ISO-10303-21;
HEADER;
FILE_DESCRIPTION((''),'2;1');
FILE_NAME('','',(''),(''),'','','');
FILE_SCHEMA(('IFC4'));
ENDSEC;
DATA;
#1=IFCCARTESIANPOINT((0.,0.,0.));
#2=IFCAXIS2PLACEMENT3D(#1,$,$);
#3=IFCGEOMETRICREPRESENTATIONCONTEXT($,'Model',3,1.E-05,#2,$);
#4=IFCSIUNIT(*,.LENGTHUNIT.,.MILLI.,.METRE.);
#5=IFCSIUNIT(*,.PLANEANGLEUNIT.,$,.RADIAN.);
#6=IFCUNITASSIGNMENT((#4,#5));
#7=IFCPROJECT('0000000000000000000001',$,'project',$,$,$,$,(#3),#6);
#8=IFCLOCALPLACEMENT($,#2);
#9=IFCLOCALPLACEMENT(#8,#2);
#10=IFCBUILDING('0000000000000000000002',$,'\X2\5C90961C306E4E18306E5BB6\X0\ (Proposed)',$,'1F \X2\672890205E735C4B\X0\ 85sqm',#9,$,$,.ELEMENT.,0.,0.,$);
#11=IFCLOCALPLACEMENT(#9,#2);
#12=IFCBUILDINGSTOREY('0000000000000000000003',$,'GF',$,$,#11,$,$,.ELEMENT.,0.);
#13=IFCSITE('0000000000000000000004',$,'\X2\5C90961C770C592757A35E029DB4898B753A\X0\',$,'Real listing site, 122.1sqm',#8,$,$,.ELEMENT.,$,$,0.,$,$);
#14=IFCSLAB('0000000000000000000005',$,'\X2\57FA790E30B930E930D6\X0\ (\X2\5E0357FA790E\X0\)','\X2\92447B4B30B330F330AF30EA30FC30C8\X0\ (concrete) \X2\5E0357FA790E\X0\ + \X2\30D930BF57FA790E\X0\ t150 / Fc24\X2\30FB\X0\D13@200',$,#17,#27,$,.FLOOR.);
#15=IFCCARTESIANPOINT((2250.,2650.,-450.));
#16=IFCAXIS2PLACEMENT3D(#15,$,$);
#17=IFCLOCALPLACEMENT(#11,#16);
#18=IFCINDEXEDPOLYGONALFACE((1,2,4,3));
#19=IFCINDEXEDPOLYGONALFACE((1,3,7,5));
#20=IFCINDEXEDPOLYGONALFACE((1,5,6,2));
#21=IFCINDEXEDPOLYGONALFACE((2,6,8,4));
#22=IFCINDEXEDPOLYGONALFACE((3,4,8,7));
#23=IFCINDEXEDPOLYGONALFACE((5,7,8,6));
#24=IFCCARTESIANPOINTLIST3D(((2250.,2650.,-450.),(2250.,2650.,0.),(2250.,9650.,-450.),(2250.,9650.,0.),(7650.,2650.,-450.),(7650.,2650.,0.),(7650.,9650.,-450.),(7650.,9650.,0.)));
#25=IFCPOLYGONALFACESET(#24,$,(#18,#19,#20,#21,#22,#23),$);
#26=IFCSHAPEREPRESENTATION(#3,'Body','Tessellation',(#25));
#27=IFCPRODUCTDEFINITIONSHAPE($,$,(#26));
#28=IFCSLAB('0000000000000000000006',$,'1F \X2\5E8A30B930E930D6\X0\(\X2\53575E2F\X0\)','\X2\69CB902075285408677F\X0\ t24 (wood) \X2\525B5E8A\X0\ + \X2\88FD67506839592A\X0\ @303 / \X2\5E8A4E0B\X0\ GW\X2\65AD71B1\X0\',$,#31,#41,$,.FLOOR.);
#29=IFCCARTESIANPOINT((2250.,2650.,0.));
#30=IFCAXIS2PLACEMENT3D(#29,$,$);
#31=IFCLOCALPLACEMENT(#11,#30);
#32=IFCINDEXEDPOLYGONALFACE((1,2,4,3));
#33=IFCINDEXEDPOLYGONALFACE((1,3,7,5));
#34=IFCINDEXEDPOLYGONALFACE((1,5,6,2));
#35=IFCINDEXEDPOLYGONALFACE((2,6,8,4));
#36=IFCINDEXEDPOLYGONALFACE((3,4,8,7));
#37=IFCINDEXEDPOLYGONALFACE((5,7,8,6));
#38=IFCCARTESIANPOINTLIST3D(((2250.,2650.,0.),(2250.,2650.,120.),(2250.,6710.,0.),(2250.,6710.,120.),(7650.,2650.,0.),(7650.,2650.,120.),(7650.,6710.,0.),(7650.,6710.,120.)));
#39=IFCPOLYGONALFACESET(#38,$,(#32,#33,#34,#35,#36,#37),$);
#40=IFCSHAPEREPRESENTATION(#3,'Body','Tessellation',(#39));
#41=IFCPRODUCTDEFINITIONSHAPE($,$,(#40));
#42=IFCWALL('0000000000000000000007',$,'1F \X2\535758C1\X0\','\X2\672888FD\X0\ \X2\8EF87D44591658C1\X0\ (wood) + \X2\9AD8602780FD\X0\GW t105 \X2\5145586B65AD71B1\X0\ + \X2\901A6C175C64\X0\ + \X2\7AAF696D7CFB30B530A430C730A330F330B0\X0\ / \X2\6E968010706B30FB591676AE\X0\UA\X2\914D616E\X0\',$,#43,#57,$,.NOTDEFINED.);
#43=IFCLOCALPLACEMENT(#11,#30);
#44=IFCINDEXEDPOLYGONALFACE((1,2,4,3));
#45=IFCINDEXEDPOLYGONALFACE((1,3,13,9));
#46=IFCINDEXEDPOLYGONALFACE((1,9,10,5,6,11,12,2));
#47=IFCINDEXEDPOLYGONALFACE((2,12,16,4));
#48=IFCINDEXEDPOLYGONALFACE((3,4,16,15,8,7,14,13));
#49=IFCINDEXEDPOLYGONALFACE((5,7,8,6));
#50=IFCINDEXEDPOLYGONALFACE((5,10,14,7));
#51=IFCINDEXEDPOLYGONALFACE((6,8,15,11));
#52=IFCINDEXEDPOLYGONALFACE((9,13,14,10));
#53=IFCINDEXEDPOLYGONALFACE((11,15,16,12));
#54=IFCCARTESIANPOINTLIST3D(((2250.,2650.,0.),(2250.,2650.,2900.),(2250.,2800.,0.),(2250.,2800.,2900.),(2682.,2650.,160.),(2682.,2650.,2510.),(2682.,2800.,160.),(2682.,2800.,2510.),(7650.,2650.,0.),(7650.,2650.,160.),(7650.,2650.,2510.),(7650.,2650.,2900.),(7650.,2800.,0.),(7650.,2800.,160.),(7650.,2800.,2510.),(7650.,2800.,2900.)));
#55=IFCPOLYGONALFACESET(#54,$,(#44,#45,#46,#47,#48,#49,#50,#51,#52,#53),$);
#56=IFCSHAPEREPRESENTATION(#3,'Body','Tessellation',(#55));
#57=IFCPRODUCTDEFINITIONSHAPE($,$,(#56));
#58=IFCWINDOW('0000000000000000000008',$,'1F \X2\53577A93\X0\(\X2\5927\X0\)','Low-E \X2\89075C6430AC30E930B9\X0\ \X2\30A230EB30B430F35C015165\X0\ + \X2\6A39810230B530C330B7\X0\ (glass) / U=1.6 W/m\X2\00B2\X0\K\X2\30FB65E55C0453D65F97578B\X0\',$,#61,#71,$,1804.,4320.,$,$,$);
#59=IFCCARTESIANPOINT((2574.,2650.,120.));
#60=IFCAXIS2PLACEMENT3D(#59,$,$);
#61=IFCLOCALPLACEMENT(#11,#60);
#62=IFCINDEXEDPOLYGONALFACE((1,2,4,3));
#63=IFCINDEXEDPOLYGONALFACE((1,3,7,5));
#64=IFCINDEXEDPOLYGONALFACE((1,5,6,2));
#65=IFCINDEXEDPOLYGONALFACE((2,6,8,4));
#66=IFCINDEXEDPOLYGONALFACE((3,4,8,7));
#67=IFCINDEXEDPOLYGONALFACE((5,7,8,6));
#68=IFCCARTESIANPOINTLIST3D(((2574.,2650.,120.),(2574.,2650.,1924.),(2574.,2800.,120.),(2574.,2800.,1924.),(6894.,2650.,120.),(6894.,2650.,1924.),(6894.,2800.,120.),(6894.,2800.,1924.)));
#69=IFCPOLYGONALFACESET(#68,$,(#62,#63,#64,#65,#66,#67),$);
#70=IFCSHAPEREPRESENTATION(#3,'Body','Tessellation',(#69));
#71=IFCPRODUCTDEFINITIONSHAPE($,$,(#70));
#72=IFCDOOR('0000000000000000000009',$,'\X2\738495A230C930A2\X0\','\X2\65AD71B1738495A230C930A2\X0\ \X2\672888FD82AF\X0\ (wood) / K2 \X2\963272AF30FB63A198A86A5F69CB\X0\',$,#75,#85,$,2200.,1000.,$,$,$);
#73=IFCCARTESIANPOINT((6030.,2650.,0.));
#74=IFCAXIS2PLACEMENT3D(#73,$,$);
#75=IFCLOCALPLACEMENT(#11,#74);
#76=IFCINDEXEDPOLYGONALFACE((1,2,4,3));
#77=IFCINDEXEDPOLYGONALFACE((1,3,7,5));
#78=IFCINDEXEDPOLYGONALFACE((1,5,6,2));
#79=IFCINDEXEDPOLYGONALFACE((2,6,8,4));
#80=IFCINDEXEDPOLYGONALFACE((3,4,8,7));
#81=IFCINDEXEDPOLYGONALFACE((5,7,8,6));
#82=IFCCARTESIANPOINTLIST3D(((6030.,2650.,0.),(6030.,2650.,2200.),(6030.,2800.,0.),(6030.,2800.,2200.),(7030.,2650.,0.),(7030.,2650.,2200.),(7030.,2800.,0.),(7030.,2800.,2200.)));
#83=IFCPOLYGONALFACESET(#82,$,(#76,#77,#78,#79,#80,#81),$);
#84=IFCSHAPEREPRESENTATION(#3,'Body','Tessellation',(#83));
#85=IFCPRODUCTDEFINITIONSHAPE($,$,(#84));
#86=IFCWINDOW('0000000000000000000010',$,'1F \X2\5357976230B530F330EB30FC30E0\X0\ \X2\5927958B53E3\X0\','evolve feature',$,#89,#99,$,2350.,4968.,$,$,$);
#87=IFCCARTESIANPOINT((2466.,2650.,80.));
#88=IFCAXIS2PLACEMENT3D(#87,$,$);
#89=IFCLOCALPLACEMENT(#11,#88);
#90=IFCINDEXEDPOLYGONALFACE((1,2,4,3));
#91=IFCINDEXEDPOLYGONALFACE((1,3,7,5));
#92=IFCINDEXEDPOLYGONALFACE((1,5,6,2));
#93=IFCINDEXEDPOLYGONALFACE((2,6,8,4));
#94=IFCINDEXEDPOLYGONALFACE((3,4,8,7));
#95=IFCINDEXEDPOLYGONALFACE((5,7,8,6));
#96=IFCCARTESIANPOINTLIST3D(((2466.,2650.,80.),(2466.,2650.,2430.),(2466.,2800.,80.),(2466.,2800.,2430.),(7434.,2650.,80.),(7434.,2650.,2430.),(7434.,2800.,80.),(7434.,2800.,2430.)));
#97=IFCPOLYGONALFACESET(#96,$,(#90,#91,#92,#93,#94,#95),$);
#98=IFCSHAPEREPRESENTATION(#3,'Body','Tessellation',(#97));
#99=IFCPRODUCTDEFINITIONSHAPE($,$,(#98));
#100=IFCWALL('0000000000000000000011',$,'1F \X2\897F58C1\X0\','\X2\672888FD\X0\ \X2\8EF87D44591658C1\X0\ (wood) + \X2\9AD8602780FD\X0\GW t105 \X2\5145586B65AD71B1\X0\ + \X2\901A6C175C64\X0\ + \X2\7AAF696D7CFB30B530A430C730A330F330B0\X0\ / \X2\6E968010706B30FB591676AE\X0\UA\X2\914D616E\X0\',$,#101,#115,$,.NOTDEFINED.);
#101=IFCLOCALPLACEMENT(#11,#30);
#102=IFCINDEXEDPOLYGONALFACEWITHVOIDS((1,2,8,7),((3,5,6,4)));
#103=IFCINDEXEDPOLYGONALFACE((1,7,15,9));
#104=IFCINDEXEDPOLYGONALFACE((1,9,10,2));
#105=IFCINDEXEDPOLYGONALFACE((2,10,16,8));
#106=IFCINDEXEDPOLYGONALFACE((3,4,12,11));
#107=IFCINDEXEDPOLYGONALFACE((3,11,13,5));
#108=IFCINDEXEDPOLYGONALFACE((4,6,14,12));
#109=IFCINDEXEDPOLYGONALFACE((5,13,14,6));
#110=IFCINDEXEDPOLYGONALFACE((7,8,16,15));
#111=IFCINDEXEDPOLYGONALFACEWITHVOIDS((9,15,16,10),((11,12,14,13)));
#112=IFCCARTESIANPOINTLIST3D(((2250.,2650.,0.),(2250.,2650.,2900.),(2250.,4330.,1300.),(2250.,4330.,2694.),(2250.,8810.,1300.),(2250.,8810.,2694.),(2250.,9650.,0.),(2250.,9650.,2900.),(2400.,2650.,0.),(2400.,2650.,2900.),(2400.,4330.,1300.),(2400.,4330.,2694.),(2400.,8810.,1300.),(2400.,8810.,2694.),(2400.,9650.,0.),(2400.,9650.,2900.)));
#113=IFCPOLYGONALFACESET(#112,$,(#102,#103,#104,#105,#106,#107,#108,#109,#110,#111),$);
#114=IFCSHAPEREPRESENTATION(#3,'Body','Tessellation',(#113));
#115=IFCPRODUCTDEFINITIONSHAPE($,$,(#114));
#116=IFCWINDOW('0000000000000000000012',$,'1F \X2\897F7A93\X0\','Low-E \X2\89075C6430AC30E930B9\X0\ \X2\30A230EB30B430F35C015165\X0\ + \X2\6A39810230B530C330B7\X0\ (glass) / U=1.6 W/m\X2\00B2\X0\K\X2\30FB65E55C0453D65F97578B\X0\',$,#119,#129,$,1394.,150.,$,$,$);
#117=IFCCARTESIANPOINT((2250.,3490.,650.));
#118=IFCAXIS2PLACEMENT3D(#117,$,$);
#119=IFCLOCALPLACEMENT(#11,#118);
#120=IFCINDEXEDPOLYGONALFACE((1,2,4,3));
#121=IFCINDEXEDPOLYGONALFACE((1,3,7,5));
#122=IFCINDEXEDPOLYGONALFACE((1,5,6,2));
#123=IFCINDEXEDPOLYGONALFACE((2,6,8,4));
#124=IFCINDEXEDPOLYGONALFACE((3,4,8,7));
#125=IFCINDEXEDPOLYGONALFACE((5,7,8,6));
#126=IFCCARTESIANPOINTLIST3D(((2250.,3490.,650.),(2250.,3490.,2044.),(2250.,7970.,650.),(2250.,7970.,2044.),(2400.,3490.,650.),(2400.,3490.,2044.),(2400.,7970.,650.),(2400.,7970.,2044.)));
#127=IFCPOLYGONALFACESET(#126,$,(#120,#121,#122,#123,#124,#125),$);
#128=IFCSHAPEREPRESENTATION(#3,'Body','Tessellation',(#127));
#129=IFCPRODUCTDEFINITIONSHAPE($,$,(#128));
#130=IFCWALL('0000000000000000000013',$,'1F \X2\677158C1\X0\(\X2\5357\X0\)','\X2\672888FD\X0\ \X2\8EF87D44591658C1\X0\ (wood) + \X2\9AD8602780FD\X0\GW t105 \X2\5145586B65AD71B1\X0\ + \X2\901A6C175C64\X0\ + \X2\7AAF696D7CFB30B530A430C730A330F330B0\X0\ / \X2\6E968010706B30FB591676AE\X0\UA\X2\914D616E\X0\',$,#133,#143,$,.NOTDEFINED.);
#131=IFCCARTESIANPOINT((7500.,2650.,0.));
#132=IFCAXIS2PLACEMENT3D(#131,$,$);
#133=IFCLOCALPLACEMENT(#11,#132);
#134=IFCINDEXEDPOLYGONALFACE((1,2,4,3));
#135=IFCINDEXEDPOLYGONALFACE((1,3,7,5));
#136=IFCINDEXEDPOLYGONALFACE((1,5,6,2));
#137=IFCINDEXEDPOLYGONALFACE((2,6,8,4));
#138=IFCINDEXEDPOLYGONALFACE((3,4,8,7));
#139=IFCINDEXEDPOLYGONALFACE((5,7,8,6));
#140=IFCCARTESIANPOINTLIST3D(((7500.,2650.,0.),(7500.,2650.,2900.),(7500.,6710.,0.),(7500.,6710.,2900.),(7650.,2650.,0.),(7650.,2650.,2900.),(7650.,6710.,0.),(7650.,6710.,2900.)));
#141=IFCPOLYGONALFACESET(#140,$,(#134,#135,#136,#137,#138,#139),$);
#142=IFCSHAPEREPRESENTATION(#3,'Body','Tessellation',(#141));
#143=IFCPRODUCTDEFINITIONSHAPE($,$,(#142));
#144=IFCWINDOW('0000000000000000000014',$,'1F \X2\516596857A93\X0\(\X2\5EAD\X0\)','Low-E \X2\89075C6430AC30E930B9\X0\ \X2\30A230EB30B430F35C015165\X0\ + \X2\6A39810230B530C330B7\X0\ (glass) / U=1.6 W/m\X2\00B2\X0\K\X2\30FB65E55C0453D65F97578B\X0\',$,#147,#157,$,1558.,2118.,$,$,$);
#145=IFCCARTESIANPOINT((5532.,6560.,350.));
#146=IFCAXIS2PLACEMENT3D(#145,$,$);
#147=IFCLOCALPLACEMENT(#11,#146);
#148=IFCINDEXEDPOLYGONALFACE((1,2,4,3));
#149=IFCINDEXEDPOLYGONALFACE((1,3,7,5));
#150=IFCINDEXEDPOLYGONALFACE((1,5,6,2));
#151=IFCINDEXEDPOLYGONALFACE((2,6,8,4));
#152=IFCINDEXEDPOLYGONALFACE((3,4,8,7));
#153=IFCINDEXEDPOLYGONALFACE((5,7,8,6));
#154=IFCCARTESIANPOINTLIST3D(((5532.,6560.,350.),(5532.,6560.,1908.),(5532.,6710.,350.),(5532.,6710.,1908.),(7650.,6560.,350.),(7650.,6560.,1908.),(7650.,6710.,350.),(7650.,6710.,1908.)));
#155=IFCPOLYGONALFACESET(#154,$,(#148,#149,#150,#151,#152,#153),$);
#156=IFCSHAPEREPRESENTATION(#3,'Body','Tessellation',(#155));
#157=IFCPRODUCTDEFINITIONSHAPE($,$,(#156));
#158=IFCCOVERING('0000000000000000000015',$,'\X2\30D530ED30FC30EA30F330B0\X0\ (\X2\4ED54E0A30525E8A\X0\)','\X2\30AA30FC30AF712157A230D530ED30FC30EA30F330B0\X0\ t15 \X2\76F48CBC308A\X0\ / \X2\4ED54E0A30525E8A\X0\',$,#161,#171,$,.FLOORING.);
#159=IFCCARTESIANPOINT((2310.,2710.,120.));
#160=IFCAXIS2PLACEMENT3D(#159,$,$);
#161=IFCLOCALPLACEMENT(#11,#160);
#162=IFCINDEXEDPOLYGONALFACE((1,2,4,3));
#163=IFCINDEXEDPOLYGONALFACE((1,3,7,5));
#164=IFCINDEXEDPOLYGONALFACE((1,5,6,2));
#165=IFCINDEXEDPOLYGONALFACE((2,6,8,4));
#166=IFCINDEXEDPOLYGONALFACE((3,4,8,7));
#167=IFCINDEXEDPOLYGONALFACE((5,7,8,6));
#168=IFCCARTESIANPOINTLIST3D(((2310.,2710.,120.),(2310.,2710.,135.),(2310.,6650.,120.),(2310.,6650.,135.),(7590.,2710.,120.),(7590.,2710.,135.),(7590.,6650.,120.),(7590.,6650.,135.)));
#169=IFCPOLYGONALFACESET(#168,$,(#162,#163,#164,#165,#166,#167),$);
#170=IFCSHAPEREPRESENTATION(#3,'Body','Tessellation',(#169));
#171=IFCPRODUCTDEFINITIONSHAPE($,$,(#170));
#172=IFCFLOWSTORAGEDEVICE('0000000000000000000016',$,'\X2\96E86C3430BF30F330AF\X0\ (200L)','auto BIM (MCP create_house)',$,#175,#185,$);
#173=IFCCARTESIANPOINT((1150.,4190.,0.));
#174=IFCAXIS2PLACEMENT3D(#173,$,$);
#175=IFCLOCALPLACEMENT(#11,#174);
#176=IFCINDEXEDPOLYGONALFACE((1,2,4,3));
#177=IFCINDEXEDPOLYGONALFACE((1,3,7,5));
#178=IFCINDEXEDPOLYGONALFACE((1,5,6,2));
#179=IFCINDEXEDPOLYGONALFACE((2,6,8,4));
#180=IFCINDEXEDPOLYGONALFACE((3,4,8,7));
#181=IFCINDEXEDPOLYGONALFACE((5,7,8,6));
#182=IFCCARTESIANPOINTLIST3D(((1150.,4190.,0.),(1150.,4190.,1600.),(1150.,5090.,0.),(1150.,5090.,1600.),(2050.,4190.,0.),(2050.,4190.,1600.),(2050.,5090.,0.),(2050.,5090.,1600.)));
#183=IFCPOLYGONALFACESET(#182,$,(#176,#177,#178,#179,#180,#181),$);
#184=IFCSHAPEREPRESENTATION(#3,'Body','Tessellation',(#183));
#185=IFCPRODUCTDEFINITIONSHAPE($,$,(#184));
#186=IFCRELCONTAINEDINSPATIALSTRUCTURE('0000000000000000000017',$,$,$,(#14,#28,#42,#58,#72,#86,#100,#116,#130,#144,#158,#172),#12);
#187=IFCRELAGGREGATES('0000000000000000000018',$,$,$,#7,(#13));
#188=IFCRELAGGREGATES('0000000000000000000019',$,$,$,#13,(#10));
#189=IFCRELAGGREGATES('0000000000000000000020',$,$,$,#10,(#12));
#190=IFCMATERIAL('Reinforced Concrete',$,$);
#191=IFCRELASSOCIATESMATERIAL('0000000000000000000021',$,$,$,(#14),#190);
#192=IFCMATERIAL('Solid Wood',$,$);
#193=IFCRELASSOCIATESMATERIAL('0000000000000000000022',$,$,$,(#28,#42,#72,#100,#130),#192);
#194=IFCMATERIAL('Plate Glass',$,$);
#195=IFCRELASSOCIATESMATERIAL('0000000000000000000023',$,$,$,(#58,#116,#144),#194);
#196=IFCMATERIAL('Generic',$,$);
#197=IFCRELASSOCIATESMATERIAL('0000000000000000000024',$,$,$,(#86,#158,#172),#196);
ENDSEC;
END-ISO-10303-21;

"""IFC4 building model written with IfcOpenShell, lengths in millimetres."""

from ifc_helpers import new_model, si_unit, frame, frame_2d, origin, place, context, project, spatial, rectangle, extrude, material, element, fill, save


model = new_model("IFC4")

# Units and contexts
model_context = context("Model", 3, precision=1e-05, world=origin())
ifc_project = project(units=[si_unit("LENGTHUNIT", "METRE", prefix="MILLI"), si_unit("PLANEANGLEUNIT", "RADIAN")], contexts=[model_context])

# Site, building, storey
site_placement = place(None, origin())
site = spatial("IfcSite", under=ifc_project, at=site_placement, Name="岐阜県大垣市鶴見町", ObjectType="Real listing site, 122.1sqm", CompositionType="ELEMENT", RefElevation=0.0)
building_placement = place(site_placement, origin())
building = spatial("IfcBuilding", under=site, at=building_placement, Name="岐阜の丘の家 (Proposed)", ObjectType="1F 木造平屋 85sqm", CompositionType="ELEMENT", ElevationOfRefHeight=0.0, ElevationOfTerrain=0.0)
storey_placement = place(building_placement, origin())
storey = spatial("IfcBuildingStorey", under=building, at=storey_placement, Name="GF", CompositionType="ELEMENT", Elevation=0.0)

# Slabs
ifc_material_1 = material(Name="Reinforced Concrete")
slab_1_placement = place(storey_placement, frame((2250.0, 2650.0, -450.0)))
element("IfcSlab", 1, at=slab_1_placement, inside=storey, material=ifc_material_1, Name="基礎スラブ (布基礎)", Description="鉄筋コンクリート (concrete) 布基礎 + ベタ基礎 t150 / Fc24・D13@200", PredefinedType="FLOOR", context=model_context, shape_type="SweptSolid", body=[
    extrude(rectangle(XDim=5400.0, YDim=7000.0, at=frame_2d((2700.0, 3500.0))), frame((2250.0, 2650.0, -450.0)), (0.0, 0.0, 1.0), 450.0),
])
ifc_material_2 = material(Name="Solid Wood")
slab_2_placement = place(storey_placement, frame((2250.0, 2650.0, 0.0)))
element("IfcSlab", 2, at=slab_2_placement, inside=storey, material=ifc_material_2, Name="1F 床スラブ(南帯)", Description="構造用合板 t24 (wood) 剛床 + 製材根太 @303 / 床下 GW断熱", PredefinedType="FLOOR", context=model_context, shape_type="SweptSolid", body=[
    extrude(rectangle(XDim=5400.0, YDim=4060.0, at=frame_2d((2700.0, 2030.0))), frame((2250.0, 2650.0, 0.0)), (0.0, 0.0, 1.0), 120.0),
])

# Wall, openings, windows, door
wall_1_placement = place(storey_placement, frame((2250.0, 2650.0, 0.0)))
wall_1 = element("IfcWall", 3, at=wall_1_placement, inside=storey, material=ifc_material_2, Name="1F 南壁", Description="木製 軸組外壁 (wood) + 高性能GW t105 充填断熱 + 通気層 + 窯業系サイディング / 準耐火・外皮UA配慮", PredefinedType="NOTDEFINED", context=model_context, shape_type="SweptSolid", body=[
    extrude(rectangle(XDim=5400.0, YDim=150.0, at=frame_2d((2700.0, 75.0))), frame((2250.0, 2650.0, 0.0)), (0.0, 0.0, 1.0), 2900.0),
])
opening_1_placement = place(storey_placement, frame((2574.0, 2650.0, 120.0)))
opening_1 = element("IfcOpeningElement", 4, at=opening_1_placement, cuts=wall_1, PredefinedType="NOTDEFINED", context=model_context, shape_type="SweptSolid", body=[
    extrude(rectangle(XDim=4320.0, YDim=150.0, at=frame_2d((2160.0, 75.0))), frame((2574.0, 2650.0, 120.0)), (0.0, 0.0, 1.0), 1804.0),
])
opening_2_placement = place(storey_placement, frame((6030.0, 2650.0, 0.0)))
opening_2 = element("IfcOpeningElement", 5, at=opening_2_placement, cuts=wall_1, PredefinedType="NOTDEFINED", context=model_context, shape_type="SweptSolid", body=[
    extrude(rectangle(XDim=1000.0, YDim=150.0, at=frame_2d((500.0, 75.0))), frame((6030.0, 2650.0, 0.0)), (0.0, 0.0, 1.0), 2200.0),
])
opening_3_placement = place(storey_placement, frame((2466.0, 2650.0, 80.0)))
opening_3 = element("IfcOpeningElement", 6, at=opening_3_placement, cuts=wall_1, PredefinedType="NOTDEFINED", context=model_context, shape_type="SweptSolid", body=[
    extrude(rectangle(XDim=4968.0, YDim=150.0, at=frame_2d((2484.0, 75.0))), frame((2466.0, 2650.0, 80.0)), (0.0, 0.0, 1.0), 2350.0),
])
ifc_material_3 = material(Name="Plate Glass")
window_1_placement = place(storey_placement, frame((2574.0, 2650.0, 120.0)))
window_1 = element("IfcWindow", 7, at=window_1_placement, inside=storey, material=ifc_material_3, Name="1F 南窓(大)", Description="Low-E 複層ガラス アルゴン封入 + 樹脂サッシ (glass) / U=1.6 W/m²K・日射取得型", OverallHeight=1804.0, OverallWidth=4320.0, context=model_context, shape_type="SweptSolid", body=[
    extrude(rectangle(XDim=4320.0, YDim=150.0, at=frame_2d((2160.0, 75.0))), frame((2574.0, 2650.0, 120.0)), (0.0, 0.0, 1.0), 1804.0),
])
fill(opening_1, window_1)
door_1_placement = place(storey_placement, frame((6030.0, 2650.0, 0.0)))
door_1 = element("IfcDoor", 8, at=door_1_placement, inside=storey, material=ifc_material_2, Name="玄関ドア", Description="断熱玄関ドア 木製芯 (wood) / K2 防犯・採風機構", OverallHeight=2200.0, OverallWidth=1000.0, context=model_context, shape_type="SweptSolid", body=[
    extrude(rectangle(XDim=1000.0, YDim=150.0, at=frame_2d((500.0, 75.0))), frame((6030.0, 2650.0, 0.0)), (0.0, 0.0, 1.0), 2200.0),
])
fill(opening_2, door_1)
ifc_material_4 = material(Name="Generic")
window_2_placement = place(storey_placement, frame((2466.0, 2650.0, 80.0)))
window_2 = element("IfcWindow", 9, at=window_2_placement, inside=storey, material=ifc_material_4, Name="1F 南面サンルーム 大開口", Description="evolve feature", OverallHeight=2350.0, OverallWidth=4968.0, context=model_context, shape_type="SweptSolid", body=[
    extrude(rectangle(XDim=4968.0, YDim=150.0, at=frame_2d((2484.0, 75.0))), frame((2466.0, 2650.0, 80.0)), (0.0, 0.0, 1.0), 2350.0),
])
fill(opening_3, window_2)

# Walls, openings, windows
wall_2_placement = place(storey_placement, frame((2250.0, 2650.0, 0.0)))
wall_2 = element("IfcWall", 10, at=wall_2_placement, inside=storey, material=ifc_material_2, Name="1F 西壁", Description="木製 軸組外壁 (wood) + 高性能GW t105 充填断熱 + 通気層 + 窯業系サイディング / 準耐火・外皮UA配慮", PredefinedType="NOTDEFINED", context=model_context, shape_type="SweptSolid", body=[
    extrude(rectangle(XDim=150.0, YDim=7000.0, at=frame_2d((75.0, 3500.0))), frame((2250.0, 2650.0, 0.0)), (0.0, 0.0, 1.0), 2900.0),
])
opening_4_placement = place(storey_placement, frame((2250.0, 3490.0, 650.0)))
opening_4 = element("IfcOpeningElement", 11, at=opening_4_placement, cuts=wall_2, PredefinedType="NOTDEFINED", context=model_context, shape_type="SweptSolid", body=[
    extrude(rectangle(XDim=150.0, YDim=4480.0, at=frame_2d((75.0, 2240.0))), frame((2250.0, 3490.0, 650.0)), (0.0, 0.0, 1.0), 1394.0),
])
window_3_placement = place(storey_placement, frame((2250.0, 3490.0, 650.0)))
window_3 = element("IfcWindow", 12, at=window_3_placement, inside=storey, material=ifc_material_3, Name="1F 西窓", Description="Low-E 複層ガラス アルゴン封入 + 樹脂サッシ (glass) / U=1.6 W/m²K・日射取得型", OverallHeight=1394.0, OverallWidth=150.0, context=model_context, shape_type="SweptSolid", body=[
    extrude(rectangle(XDim=150.0, YDim=4480.0, at=frame_2d((75.0, 2240.0))), frame((2250.0, 3490.0, 650.0)), (0.0, 0.0, 1.0), 1394.0),
])
fill(opening_4, window_3)
wall_3_placement = place(storey_placement, frame((7500.0, 2650.0, 0.0)))
wall_3 = element("IfcWall", 13, at=wall_3_placement, inside=storey, material=ifc_material_2, Name="1F 東壁(南)", Description="木製 軸組外壁 (wood) + 高性能GW t105 充填断熱 + 通気層 + 窯業系サイディング / 準耐火・外皮UA配慮", PredefinedType="NOTDEFINED", context=model_context, shape_type="SweptSolid", body=[
    extrude(rectangle(XDim=150.0, YDim=4060.0, at=frame_2d((75.0, 2030.0))), frame((7500.0, 2650.0, 0.0)), (0.0, 0.0, 1.0), 2900.0),
])
opening_5_placement = place(storey_placement, frame((5532.0, 6560.0, 350.0)))
opening_5 = element("IfcOpeningElement", 14, at=opening_5_placement, cuts=wall_3, PredefinedType="NOTDEFINED", context=model_context, shape_type="SweptSolid", body=[
    extrude(rectangle(XDim=2118.0, YDim=150.0, at=frame_2d((1059.0, 75.0))), frame((5532.0, 6560.0, 350.0)), (0.0, 0.0, 1.0), 1558.0),
])
window_4_placement = place(storey_placement, frame((5532.0, 6560.0, 350.0)))
window_4 = element("IfcWindow", 15, at=window_4_placement, inside=storey, material=ifc_material_3, Name="1F 入隅窓(庭)", Description="Low-E 複層ガラス アルゴン封入 + 樹脂サッシ (glass) / U=1.6 W/m²K・日射取得型", OverallHeight=1558.0, OverallWidth=2118.0, context=model_context, shape_type="SweptSolid", body=[
    extrude(rectangle(XDim=2118.0, YDim=150.0, at=frame_2d((1059.0, 75.0))), frame((5532.0, 6560.0, 350.0)), (0.0, 0.0, 1.0), 1558.0),
])
fill(opening_5, window_4)

# Covering
covering_placement = place(storey_placement, frame((2310.0, 2710.0, 120.0)))
element("IfcCovering", 16, at=covering_placement, inside=storey, material=ifc_material_4, Name="フローリング (仕上げ床)", Description="オーク無垢フローリング t15 直貼り / 仕上げ床", PredefinedType="FLOORING", context=model_context, shape_type="SweptSolid", body=[
    extrude(rectangle(XDim=5280.0, YDim=3940.0, at=frame_2d((2640.0, 1970.0))), frame((2310.0, 2710.0, 120.0)), (0.0, 0.0, 1.0), 15.0),
])

# Flow storage device
flow_storage_device_placement = place(storey_placement, frame((1150.0, 4190.0, 0.0)))
element("IfcFlowStorageDevice", 17, at=flow_storage_device_placement, inside=storey, material=ifc_material_4, Name="雨水タンク (200L)", Description="auto BIM (MCP create_house)", context=model_context, shape_type="SweptSolid", body=[
    extrude(rectangle(XDim=900.0, YDim=900.0, at=frame_2d((450.0, 450.0))), frame((1150.0, 4190.0, 0.0)), (0.0, 0.0, 1.0), 1600.0),
])

save(model, "model.ifc")
